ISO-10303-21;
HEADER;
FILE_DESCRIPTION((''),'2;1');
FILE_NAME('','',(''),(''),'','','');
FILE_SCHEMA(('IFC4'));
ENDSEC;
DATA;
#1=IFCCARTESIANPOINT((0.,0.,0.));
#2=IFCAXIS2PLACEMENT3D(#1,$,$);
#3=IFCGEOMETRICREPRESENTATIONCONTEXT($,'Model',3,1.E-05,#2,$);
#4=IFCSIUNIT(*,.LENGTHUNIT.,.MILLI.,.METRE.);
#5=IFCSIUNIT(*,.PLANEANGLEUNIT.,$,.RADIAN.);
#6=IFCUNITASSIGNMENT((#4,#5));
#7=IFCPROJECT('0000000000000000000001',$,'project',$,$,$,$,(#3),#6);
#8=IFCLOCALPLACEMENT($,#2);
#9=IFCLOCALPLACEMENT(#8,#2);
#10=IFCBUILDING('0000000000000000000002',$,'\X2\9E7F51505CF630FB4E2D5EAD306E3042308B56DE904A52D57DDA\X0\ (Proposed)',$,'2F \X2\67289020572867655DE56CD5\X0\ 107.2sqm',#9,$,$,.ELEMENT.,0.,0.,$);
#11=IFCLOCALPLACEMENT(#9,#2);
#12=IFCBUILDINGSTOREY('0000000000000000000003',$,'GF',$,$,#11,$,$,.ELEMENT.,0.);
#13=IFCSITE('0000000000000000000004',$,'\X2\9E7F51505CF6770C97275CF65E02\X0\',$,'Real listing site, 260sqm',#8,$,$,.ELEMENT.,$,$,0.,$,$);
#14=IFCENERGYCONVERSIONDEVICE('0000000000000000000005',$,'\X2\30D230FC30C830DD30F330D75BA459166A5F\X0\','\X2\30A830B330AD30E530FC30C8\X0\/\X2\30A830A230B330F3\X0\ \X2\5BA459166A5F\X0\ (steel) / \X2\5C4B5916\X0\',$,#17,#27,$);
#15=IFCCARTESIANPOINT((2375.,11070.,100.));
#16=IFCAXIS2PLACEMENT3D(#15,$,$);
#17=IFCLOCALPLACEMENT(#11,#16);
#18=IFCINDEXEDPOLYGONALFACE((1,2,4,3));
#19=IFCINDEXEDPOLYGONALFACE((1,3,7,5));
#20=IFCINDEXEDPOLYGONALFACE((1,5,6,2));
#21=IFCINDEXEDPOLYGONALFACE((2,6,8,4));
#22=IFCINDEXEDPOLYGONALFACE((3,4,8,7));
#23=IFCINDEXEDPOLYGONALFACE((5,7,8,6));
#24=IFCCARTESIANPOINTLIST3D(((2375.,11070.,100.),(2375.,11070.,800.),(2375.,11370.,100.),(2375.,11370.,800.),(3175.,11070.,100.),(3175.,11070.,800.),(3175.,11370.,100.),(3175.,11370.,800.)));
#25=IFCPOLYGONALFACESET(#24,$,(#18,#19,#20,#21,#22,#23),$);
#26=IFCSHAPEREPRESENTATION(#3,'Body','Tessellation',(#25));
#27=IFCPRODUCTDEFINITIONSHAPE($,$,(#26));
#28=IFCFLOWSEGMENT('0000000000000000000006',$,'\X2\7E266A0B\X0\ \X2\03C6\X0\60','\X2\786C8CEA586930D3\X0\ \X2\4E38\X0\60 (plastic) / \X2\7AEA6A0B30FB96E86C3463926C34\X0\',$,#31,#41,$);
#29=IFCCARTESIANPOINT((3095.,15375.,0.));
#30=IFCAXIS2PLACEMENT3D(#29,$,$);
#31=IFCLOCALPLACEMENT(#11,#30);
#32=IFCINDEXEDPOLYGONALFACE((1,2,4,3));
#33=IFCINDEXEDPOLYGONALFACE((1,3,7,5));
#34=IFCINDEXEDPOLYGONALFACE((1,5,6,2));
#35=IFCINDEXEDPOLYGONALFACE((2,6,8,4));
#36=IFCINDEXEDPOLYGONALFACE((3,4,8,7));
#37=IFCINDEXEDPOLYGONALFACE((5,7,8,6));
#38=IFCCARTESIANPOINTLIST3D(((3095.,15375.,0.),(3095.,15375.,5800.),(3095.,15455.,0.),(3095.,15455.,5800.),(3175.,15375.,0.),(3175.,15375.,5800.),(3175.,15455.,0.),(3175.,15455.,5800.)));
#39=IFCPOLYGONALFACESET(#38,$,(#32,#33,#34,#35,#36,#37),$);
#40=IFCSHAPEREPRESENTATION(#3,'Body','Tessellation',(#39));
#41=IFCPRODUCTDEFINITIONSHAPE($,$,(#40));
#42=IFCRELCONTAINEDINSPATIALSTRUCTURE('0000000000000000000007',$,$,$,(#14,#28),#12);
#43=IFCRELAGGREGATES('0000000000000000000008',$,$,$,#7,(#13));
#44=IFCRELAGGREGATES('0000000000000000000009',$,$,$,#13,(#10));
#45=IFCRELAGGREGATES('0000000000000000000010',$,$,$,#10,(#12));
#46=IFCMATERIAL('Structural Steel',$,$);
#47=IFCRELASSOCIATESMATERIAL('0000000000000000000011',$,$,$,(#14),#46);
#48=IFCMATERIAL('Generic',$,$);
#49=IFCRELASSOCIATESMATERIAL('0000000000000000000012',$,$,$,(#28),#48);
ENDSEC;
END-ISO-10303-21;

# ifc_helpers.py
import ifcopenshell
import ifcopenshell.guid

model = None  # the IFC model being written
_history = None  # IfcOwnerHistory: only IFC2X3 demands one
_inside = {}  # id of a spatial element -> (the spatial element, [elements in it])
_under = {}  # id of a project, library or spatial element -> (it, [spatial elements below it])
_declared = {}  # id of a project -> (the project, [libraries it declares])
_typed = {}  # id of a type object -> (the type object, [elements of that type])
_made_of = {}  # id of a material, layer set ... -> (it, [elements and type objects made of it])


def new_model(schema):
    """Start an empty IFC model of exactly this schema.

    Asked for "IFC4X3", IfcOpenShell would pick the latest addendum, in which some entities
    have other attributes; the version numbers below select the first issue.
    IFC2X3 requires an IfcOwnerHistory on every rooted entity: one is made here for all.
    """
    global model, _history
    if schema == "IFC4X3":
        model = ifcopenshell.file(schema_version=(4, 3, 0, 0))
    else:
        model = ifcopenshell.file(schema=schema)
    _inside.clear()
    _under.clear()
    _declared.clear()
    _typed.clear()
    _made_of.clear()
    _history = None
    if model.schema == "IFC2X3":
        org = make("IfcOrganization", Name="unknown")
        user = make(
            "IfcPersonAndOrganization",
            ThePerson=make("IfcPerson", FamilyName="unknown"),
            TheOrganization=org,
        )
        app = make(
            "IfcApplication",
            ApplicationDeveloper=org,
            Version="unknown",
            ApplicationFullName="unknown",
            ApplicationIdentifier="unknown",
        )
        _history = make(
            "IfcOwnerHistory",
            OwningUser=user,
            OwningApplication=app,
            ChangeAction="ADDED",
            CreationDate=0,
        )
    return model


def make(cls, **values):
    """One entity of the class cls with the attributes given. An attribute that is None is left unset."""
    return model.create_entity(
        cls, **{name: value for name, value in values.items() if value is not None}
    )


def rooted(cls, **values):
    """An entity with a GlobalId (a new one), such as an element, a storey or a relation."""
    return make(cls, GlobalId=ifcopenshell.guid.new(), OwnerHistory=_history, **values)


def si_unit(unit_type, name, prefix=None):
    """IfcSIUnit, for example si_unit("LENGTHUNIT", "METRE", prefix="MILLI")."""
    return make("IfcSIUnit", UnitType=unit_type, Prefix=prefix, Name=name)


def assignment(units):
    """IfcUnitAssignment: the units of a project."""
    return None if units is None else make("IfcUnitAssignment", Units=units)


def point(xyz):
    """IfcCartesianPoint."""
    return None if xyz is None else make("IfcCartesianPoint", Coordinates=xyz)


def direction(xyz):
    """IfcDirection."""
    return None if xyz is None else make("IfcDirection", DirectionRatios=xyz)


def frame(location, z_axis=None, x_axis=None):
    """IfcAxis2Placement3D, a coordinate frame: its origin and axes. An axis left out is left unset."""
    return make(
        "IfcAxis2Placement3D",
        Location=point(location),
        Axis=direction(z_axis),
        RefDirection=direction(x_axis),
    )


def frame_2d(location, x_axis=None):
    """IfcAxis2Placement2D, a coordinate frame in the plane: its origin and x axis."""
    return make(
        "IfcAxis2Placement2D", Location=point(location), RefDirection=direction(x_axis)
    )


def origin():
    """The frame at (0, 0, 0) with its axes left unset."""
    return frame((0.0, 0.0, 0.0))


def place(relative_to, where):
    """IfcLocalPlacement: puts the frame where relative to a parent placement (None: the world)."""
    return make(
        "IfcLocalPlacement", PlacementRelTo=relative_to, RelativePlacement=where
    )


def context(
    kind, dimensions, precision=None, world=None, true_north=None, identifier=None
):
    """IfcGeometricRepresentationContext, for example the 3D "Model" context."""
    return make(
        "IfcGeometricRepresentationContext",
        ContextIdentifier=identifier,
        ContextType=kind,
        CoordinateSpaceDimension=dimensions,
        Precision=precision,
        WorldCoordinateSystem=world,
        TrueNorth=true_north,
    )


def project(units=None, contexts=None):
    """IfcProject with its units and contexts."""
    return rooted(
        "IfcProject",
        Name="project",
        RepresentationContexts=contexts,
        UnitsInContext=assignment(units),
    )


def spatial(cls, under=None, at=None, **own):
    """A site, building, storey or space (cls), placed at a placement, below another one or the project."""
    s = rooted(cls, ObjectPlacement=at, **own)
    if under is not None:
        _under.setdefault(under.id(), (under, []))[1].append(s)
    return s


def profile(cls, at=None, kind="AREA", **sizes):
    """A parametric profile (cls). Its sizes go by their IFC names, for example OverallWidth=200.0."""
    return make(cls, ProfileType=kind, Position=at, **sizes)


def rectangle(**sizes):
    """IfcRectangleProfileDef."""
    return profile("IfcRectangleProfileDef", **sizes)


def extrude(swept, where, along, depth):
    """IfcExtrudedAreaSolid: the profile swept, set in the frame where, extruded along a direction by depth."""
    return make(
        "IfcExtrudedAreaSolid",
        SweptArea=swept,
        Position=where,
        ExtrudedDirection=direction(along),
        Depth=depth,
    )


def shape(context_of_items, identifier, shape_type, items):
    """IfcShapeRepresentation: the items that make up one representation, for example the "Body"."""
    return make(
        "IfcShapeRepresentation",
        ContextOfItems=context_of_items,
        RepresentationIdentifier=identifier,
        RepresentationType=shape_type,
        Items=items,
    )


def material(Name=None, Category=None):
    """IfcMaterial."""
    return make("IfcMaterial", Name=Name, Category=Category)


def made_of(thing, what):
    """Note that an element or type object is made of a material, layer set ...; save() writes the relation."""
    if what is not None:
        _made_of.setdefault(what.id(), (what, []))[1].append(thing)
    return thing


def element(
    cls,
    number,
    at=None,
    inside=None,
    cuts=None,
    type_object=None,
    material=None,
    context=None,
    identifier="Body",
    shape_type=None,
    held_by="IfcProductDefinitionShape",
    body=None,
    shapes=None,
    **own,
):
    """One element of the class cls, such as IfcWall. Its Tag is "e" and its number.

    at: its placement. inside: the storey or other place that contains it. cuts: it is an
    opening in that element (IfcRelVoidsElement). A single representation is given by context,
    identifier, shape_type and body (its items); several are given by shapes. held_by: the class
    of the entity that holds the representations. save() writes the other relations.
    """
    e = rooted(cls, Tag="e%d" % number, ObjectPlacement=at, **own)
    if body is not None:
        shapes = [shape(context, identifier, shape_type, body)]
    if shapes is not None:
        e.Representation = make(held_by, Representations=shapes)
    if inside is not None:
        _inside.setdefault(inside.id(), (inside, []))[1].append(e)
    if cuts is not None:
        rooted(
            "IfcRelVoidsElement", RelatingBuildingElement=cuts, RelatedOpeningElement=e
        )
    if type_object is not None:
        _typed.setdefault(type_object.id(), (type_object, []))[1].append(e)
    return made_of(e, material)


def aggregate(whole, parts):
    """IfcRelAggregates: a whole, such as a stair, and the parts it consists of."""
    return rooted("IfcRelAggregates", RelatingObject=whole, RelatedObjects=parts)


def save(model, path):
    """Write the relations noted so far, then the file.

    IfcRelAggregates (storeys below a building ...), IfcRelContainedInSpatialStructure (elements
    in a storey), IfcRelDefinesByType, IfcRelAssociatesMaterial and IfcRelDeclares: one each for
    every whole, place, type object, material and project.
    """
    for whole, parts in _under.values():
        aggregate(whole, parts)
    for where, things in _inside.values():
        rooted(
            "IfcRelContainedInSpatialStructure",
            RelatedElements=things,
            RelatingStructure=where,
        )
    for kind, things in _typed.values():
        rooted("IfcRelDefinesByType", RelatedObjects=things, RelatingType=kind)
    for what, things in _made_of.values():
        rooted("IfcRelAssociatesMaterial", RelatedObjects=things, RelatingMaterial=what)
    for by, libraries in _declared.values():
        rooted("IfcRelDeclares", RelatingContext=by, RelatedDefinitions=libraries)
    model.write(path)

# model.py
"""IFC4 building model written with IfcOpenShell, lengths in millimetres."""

from ifc_helpers import new_model, si_unit, frame, frame_2d, origin, place, context, project, spatial, rectangle, extrude, material, element, save


model = new_model("IFC4")

# Units and contexts
model_context = context("Model", 3, precision=1e-05, world=origin())
ifc_project = project(units=[si_unit("LENGTHUNIT", "METRE", prefix="MILLI"), si_unit("PLANEANGLEUNIT", "RADIAN")], contexts=[model_context])

# Site, building, storey
site_placement = place(None, origin())
site = spatial("IfcSite", under=ifc_project, at=site_placement, Name="鹿児島県霧島市", ObjectType="Real listing site, 260sqm", CompositionType="ELEMENT", RefElevation=0.0)
building_placement = place(site_placement, origin())
building = spatial("IfcBuilding", under=site, at=building_placement, Name="鹿児島・中庭のある回遊動線 (Proposed)", ObjectType="2F 木造在来工法 107.2sqm", CompositionType="ELEMENT", ElevationOfRefHeight=0.0, ElevationOfTerrain=0.0)
storey_placement = place(building_placement, origin())
storey = spatial("IfcBuildingStorey", under=building, at=storey_placement, Name="GF", CompositionType="ELEMENT", Elevation=0.0)

# Shared definitions
ifc_material_1 = material(Name="Generic")

# Energy conversion device
ifc_material_2 = material(Name="Structural Steel")
energy_conversion_device_placement = place(storey_placement, frame((2375.0, 11070.0, 100.0)))
element("IfcEnergyConversionDevice", 1, at=energy_conversion_device_placement, inside=storey, material=ifc_material_2, Name="ヒートポンプ室外機", Description="エコキュート/エアコン 室外機 (steel) / 屋外", context=model_context, shape_type="SweptSolid", body=[
    extrude(rectangle(XDim=800.0, YDim=300.0, at=frame_2d((400.0, 150.0))), frame((2375.0, 11070.0, 100.0)), (0.0, 0.0, 1.0), 700.0),
])

# Flow segment
flow_segment_placement = place(storey_placement, frame((3095.0, 15375.0, 0.0)))
element("IfcFlowSegment", 2, at=flow_segment_placement, inside=storey, material=ifc_material_1, Name="縦樋 φ60", Description="硬質塩ビ 丸60 (plastic) / 竪樋・雨水排水", context=model_context, shape_type="SweptSolid", body=[
    extrude(rectangle(XDim=80.0, YDim=80.0, at=frame_2d((40.0, 40.0))), frame((3095.0, 15375.0, 0.0)), (0.0, 0.0, 1.0), 5800.0),
])

save(model, "model.ifc")
